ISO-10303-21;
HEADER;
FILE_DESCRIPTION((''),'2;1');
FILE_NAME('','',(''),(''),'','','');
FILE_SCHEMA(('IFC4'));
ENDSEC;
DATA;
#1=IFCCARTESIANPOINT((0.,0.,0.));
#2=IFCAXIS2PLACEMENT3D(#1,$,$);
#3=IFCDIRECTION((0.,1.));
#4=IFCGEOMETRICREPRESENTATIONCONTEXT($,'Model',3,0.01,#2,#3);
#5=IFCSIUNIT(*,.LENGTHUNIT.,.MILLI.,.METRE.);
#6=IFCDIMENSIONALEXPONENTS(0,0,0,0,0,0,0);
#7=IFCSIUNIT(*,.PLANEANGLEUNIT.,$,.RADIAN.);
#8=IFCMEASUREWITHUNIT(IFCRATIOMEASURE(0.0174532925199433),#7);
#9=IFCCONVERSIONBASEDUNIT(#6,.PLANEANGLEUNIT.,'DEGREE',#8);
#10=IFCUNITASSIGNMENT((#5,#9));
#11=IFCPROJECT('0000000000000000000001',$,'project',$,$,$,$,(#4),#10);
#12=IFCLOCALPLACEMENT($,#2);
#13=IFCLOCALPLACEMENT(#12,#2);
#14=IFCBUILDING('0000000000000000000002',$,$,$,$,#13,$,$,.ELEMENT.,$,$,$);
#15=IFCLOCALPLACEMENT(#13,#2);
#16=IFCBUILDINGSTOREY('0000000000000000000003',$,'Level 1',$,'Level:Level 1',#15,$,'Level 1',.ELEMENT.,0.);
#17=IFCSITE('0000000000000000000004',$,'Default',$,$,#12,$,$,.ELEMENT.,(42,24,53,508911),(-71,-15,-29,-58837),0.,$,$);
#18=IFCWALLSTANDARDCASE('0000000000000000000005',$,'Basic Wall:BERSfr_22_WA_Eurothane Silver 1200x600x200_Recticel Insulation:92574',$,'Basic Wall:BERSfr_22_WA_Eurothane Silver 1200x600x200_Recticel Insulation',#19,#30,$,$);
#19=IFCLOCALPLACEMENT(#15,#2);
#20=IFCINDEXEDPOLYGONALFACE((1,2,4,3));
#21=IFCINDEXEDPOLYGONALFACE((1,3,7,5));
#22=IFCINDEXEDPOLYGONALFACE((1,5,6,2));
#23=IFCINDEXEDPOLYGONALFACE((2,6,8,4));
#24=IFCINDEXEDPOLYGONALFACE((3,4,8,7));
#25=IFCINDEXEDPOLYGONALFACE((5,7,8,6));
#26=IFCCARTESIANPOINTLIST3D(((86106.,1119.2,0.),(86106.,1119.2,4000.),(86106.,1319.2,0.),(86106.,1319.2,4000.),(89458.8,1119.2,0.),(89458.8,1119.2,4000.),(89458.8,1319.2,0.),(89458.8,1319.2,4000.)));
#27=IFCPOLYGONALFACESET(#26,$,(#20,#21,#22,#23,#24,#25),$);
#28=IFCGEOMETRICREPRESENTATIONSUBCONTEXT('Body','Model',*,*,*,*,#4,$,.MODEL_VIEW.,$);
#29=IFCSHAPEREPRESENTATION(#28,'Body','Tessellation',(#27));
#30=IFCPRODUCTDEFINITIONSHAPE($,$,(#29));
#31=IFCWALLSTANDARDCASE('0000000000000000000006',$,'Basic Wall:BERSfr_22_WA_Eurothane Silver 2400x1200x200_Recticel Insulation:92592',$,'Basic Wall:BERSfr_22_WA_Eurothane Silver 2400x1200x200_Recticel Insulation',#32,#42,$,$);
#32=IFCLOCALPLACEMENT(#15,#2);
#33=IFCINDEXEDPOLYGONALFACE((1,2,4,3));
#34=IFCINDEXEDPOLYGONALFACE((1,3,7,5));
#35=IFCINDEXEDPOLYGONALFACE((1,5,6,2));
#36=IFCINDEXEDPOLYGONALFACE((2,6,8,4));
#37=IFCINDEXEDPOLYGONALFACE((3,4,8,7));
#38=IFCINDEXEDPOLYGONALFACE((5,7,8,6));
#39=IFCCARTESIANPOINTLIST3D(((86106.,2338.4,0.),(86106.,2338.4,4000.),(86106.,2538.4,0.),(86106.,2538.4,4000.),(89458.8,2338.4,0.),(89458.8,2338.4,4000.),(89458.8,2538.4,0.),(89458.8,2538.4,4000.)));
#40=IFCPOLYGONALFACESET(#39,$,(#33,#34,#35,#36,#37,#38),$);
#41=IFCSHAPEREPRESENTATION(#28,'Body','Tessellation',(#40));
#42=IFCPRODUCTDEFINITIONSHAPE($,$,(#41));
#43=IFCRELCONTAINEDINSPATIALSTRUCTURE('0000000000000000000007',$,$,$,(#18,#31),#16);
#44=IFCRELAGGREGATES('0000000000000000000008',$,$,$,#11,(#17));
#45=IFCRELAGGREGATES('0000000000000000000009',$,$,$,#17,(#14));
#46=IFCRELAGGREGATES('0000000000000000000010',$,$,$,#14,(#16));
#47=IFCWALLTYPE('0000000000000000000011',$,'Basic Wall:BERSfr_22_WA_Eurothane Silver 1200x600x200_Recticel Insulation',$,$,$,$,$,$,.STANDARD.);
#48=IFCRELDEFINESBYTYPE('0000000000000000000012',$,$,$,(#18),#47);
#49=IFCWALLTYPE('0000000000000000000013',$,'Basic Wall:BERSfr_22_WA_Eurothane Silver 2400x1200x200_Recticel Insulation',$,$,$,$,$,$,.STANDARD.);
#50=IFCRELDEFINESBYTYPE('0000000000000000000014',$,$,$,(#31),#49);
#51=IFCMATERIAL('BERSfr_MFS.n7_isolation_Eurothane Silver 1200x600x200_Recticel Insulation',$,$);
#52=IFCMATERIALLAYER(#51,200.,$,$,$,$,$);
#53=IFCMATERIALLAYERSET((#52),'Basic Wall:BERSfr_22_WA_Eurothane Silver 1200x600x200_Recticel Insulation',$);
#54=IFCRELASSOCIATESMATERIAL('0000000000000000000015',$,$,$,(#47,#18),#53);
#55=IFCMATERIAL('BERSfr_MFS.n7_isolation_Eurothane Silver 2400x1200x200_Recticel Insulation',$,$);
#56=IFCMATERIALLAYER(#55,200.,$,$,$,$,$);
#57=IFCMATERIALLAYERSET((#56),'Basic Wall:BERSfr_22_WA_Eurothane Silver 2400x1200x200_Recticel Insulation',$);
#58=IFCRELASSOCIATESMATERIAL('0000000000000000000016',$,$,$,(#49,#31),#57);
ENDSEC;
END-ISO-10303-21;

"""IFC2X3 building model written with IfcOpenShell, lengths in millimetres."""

from ifc_helpers import new_model, entity, si_unit, converted_unit, direction, frame, frame_2d, origin, place, context, subcontext, project, spatial, rectangle, extrude, material, layer, layer_set, layer_usage, type_object, element, save


model = new_model("IFC2X3")

# Units and contexts
model_context = context("Model", 3, precision=0.01, world=origin(), true_north=direction((0.0, 1.0)))
body_context = subcontext(model_context, "Body", "Model", "MODEL_VIEW")
ifc_project = project(units=[si_unit("LENGTHUNIT", "METRE", prefix="MILLI"), converted_unit("PLANEANGLEUNIT", "DEGREE", entity("IfcRatioMeasure", 0.0174532925199433), si_unit("PLANEANGLEUNIT", "RADIAN"), dimensions=[0, 0, 0, 0, 0, 0, 0])], contexts=[model_context])

# Site, building, storey
site_placement = place(None, origin())
site = spatial("IfcSite", under=ifc_project, at=site_placement, Name="Default", CompositionType="ELEMENT", RefLatitude=(42, 24, 53, 508911), RefLongitude=(-71, -15, -29, -58837), RefElevation=0.0)
building_placement = place(site_placement, origin())
building = spatial("IfcBuilding", under=site, at=building_placement, CompositionType="ELEMENT")
storey_placement = place(building_placement, origin())
storey = spatial("IfcBuildingStorey", under=building, at=storey_placement, Name="Level 1", ObjectType="Level:Level 1", LongName="Level 1", CompositionType="ELEMENT", Elevation=0.0)

# Shared definitions
ifc_material_1 = material(Name="BERSfr_MFS.n7_isolation_Eurothane Silver 1200x600x200_Recticel Insulation")
ifc_material_2 = material(Name="BERSfr_MFS.n7_isolation_Eurothane Silver 2400x1200x200_Recticel Insulation")

# Walls
ifc_layer_1 = layer(ifc_material_1, 200.0)
ifc_layer_set_1 = layer_set([ifc_layer_1], Name="Basic Wall:BERSfr_22_WA_Eurothane Silver 1200x600x200_Recticel Insulation")
ifc_layer_usage_1 = layer_usage(ifc_layer_set_1, "AXIS2", "NEGATIVE", 100.0)
wall_type_1 = type_object("IfcWallType", Name="Basic Wall:BERSfr_22_WA_Eurothane Silver 1200x600x200_Recticel Insulation", PredefinedType="STANDARD", material=ifc_layer_set_1)
wall_1_placement = place(storey_placement, frame((86106.0, 1219.2, 0.0)))
element("IfcWallStandardCase", 1, at=wall_1_placement, inside=storey, type_object=wall_type_1, material=ifc_layer_usage_1, Name="Basic Wall:BERSfr_22_WA_Eurothane Silver 1200x600x200_Recticel Insulation:92574", ObjectType="Basic Wall:BERSfr_22_WA_Eurothane Silver 1200x600x200_Recticel Insulation", context=body_context, shape_type="SweptSolid", body=[
    extrude(rectangle(XDim=3352.8, YDim=200.0, at=frame_2d((1676.4, 0.0), x_axis=(-1.0, 0.0))), origin(), (0.0, 0.0, 1.0), 4000.0),
])
ifc_layer_2 = layer(ifc_material_2, 200.0)
ifc_layer_set_2 = layer_set([ifc_layer_2], Name="Basic Wall:BERSfr_22_WA_Eurothane Silver 2400x1200x200_Recticel Insulation")
ifc_layer_usage_2 = layer_usage(ifc_layer_set_2, "AXIS2", "NEGATIVE", 100.0)
wall_type_2 = type_object("IfcWallType", Name="Basic Wall:BERSfr_22_WA_Eurothane Silver 2400x1200x200_Recticel Insulation", PredefinedType="STANDARD", material=ifc_layer_set_2)
wall_2_placement = place(storey_placement, frame((86106.0, 2438.4, 0.0)))
element("IfcWallStandardCase", 2, at=wall_2_placement, inside=storey, type_object=wall_type_2, material=ifc_layer_usage_2, Name="Basic Wall:BERSfr_22_WA_Eurothane Silver 2400x1200x200_Recticel Insulation:92592", ObjectType="Basic Wall:BERSfr_22_WA_Eurothane Silver 2400x1200x200_Recticel Insulation", context=body_context, shape_type="SweptSolid", body=[
    extrude(rectangle(XDim=3352.8, YDim=200.0, at=frame_2d((1676.4, 0.0), x_axis=(-1.0, 0.0))), origin(), (0.0, 0.0, 1.0), 4000.0),
])

save(model, "model.ifc")
